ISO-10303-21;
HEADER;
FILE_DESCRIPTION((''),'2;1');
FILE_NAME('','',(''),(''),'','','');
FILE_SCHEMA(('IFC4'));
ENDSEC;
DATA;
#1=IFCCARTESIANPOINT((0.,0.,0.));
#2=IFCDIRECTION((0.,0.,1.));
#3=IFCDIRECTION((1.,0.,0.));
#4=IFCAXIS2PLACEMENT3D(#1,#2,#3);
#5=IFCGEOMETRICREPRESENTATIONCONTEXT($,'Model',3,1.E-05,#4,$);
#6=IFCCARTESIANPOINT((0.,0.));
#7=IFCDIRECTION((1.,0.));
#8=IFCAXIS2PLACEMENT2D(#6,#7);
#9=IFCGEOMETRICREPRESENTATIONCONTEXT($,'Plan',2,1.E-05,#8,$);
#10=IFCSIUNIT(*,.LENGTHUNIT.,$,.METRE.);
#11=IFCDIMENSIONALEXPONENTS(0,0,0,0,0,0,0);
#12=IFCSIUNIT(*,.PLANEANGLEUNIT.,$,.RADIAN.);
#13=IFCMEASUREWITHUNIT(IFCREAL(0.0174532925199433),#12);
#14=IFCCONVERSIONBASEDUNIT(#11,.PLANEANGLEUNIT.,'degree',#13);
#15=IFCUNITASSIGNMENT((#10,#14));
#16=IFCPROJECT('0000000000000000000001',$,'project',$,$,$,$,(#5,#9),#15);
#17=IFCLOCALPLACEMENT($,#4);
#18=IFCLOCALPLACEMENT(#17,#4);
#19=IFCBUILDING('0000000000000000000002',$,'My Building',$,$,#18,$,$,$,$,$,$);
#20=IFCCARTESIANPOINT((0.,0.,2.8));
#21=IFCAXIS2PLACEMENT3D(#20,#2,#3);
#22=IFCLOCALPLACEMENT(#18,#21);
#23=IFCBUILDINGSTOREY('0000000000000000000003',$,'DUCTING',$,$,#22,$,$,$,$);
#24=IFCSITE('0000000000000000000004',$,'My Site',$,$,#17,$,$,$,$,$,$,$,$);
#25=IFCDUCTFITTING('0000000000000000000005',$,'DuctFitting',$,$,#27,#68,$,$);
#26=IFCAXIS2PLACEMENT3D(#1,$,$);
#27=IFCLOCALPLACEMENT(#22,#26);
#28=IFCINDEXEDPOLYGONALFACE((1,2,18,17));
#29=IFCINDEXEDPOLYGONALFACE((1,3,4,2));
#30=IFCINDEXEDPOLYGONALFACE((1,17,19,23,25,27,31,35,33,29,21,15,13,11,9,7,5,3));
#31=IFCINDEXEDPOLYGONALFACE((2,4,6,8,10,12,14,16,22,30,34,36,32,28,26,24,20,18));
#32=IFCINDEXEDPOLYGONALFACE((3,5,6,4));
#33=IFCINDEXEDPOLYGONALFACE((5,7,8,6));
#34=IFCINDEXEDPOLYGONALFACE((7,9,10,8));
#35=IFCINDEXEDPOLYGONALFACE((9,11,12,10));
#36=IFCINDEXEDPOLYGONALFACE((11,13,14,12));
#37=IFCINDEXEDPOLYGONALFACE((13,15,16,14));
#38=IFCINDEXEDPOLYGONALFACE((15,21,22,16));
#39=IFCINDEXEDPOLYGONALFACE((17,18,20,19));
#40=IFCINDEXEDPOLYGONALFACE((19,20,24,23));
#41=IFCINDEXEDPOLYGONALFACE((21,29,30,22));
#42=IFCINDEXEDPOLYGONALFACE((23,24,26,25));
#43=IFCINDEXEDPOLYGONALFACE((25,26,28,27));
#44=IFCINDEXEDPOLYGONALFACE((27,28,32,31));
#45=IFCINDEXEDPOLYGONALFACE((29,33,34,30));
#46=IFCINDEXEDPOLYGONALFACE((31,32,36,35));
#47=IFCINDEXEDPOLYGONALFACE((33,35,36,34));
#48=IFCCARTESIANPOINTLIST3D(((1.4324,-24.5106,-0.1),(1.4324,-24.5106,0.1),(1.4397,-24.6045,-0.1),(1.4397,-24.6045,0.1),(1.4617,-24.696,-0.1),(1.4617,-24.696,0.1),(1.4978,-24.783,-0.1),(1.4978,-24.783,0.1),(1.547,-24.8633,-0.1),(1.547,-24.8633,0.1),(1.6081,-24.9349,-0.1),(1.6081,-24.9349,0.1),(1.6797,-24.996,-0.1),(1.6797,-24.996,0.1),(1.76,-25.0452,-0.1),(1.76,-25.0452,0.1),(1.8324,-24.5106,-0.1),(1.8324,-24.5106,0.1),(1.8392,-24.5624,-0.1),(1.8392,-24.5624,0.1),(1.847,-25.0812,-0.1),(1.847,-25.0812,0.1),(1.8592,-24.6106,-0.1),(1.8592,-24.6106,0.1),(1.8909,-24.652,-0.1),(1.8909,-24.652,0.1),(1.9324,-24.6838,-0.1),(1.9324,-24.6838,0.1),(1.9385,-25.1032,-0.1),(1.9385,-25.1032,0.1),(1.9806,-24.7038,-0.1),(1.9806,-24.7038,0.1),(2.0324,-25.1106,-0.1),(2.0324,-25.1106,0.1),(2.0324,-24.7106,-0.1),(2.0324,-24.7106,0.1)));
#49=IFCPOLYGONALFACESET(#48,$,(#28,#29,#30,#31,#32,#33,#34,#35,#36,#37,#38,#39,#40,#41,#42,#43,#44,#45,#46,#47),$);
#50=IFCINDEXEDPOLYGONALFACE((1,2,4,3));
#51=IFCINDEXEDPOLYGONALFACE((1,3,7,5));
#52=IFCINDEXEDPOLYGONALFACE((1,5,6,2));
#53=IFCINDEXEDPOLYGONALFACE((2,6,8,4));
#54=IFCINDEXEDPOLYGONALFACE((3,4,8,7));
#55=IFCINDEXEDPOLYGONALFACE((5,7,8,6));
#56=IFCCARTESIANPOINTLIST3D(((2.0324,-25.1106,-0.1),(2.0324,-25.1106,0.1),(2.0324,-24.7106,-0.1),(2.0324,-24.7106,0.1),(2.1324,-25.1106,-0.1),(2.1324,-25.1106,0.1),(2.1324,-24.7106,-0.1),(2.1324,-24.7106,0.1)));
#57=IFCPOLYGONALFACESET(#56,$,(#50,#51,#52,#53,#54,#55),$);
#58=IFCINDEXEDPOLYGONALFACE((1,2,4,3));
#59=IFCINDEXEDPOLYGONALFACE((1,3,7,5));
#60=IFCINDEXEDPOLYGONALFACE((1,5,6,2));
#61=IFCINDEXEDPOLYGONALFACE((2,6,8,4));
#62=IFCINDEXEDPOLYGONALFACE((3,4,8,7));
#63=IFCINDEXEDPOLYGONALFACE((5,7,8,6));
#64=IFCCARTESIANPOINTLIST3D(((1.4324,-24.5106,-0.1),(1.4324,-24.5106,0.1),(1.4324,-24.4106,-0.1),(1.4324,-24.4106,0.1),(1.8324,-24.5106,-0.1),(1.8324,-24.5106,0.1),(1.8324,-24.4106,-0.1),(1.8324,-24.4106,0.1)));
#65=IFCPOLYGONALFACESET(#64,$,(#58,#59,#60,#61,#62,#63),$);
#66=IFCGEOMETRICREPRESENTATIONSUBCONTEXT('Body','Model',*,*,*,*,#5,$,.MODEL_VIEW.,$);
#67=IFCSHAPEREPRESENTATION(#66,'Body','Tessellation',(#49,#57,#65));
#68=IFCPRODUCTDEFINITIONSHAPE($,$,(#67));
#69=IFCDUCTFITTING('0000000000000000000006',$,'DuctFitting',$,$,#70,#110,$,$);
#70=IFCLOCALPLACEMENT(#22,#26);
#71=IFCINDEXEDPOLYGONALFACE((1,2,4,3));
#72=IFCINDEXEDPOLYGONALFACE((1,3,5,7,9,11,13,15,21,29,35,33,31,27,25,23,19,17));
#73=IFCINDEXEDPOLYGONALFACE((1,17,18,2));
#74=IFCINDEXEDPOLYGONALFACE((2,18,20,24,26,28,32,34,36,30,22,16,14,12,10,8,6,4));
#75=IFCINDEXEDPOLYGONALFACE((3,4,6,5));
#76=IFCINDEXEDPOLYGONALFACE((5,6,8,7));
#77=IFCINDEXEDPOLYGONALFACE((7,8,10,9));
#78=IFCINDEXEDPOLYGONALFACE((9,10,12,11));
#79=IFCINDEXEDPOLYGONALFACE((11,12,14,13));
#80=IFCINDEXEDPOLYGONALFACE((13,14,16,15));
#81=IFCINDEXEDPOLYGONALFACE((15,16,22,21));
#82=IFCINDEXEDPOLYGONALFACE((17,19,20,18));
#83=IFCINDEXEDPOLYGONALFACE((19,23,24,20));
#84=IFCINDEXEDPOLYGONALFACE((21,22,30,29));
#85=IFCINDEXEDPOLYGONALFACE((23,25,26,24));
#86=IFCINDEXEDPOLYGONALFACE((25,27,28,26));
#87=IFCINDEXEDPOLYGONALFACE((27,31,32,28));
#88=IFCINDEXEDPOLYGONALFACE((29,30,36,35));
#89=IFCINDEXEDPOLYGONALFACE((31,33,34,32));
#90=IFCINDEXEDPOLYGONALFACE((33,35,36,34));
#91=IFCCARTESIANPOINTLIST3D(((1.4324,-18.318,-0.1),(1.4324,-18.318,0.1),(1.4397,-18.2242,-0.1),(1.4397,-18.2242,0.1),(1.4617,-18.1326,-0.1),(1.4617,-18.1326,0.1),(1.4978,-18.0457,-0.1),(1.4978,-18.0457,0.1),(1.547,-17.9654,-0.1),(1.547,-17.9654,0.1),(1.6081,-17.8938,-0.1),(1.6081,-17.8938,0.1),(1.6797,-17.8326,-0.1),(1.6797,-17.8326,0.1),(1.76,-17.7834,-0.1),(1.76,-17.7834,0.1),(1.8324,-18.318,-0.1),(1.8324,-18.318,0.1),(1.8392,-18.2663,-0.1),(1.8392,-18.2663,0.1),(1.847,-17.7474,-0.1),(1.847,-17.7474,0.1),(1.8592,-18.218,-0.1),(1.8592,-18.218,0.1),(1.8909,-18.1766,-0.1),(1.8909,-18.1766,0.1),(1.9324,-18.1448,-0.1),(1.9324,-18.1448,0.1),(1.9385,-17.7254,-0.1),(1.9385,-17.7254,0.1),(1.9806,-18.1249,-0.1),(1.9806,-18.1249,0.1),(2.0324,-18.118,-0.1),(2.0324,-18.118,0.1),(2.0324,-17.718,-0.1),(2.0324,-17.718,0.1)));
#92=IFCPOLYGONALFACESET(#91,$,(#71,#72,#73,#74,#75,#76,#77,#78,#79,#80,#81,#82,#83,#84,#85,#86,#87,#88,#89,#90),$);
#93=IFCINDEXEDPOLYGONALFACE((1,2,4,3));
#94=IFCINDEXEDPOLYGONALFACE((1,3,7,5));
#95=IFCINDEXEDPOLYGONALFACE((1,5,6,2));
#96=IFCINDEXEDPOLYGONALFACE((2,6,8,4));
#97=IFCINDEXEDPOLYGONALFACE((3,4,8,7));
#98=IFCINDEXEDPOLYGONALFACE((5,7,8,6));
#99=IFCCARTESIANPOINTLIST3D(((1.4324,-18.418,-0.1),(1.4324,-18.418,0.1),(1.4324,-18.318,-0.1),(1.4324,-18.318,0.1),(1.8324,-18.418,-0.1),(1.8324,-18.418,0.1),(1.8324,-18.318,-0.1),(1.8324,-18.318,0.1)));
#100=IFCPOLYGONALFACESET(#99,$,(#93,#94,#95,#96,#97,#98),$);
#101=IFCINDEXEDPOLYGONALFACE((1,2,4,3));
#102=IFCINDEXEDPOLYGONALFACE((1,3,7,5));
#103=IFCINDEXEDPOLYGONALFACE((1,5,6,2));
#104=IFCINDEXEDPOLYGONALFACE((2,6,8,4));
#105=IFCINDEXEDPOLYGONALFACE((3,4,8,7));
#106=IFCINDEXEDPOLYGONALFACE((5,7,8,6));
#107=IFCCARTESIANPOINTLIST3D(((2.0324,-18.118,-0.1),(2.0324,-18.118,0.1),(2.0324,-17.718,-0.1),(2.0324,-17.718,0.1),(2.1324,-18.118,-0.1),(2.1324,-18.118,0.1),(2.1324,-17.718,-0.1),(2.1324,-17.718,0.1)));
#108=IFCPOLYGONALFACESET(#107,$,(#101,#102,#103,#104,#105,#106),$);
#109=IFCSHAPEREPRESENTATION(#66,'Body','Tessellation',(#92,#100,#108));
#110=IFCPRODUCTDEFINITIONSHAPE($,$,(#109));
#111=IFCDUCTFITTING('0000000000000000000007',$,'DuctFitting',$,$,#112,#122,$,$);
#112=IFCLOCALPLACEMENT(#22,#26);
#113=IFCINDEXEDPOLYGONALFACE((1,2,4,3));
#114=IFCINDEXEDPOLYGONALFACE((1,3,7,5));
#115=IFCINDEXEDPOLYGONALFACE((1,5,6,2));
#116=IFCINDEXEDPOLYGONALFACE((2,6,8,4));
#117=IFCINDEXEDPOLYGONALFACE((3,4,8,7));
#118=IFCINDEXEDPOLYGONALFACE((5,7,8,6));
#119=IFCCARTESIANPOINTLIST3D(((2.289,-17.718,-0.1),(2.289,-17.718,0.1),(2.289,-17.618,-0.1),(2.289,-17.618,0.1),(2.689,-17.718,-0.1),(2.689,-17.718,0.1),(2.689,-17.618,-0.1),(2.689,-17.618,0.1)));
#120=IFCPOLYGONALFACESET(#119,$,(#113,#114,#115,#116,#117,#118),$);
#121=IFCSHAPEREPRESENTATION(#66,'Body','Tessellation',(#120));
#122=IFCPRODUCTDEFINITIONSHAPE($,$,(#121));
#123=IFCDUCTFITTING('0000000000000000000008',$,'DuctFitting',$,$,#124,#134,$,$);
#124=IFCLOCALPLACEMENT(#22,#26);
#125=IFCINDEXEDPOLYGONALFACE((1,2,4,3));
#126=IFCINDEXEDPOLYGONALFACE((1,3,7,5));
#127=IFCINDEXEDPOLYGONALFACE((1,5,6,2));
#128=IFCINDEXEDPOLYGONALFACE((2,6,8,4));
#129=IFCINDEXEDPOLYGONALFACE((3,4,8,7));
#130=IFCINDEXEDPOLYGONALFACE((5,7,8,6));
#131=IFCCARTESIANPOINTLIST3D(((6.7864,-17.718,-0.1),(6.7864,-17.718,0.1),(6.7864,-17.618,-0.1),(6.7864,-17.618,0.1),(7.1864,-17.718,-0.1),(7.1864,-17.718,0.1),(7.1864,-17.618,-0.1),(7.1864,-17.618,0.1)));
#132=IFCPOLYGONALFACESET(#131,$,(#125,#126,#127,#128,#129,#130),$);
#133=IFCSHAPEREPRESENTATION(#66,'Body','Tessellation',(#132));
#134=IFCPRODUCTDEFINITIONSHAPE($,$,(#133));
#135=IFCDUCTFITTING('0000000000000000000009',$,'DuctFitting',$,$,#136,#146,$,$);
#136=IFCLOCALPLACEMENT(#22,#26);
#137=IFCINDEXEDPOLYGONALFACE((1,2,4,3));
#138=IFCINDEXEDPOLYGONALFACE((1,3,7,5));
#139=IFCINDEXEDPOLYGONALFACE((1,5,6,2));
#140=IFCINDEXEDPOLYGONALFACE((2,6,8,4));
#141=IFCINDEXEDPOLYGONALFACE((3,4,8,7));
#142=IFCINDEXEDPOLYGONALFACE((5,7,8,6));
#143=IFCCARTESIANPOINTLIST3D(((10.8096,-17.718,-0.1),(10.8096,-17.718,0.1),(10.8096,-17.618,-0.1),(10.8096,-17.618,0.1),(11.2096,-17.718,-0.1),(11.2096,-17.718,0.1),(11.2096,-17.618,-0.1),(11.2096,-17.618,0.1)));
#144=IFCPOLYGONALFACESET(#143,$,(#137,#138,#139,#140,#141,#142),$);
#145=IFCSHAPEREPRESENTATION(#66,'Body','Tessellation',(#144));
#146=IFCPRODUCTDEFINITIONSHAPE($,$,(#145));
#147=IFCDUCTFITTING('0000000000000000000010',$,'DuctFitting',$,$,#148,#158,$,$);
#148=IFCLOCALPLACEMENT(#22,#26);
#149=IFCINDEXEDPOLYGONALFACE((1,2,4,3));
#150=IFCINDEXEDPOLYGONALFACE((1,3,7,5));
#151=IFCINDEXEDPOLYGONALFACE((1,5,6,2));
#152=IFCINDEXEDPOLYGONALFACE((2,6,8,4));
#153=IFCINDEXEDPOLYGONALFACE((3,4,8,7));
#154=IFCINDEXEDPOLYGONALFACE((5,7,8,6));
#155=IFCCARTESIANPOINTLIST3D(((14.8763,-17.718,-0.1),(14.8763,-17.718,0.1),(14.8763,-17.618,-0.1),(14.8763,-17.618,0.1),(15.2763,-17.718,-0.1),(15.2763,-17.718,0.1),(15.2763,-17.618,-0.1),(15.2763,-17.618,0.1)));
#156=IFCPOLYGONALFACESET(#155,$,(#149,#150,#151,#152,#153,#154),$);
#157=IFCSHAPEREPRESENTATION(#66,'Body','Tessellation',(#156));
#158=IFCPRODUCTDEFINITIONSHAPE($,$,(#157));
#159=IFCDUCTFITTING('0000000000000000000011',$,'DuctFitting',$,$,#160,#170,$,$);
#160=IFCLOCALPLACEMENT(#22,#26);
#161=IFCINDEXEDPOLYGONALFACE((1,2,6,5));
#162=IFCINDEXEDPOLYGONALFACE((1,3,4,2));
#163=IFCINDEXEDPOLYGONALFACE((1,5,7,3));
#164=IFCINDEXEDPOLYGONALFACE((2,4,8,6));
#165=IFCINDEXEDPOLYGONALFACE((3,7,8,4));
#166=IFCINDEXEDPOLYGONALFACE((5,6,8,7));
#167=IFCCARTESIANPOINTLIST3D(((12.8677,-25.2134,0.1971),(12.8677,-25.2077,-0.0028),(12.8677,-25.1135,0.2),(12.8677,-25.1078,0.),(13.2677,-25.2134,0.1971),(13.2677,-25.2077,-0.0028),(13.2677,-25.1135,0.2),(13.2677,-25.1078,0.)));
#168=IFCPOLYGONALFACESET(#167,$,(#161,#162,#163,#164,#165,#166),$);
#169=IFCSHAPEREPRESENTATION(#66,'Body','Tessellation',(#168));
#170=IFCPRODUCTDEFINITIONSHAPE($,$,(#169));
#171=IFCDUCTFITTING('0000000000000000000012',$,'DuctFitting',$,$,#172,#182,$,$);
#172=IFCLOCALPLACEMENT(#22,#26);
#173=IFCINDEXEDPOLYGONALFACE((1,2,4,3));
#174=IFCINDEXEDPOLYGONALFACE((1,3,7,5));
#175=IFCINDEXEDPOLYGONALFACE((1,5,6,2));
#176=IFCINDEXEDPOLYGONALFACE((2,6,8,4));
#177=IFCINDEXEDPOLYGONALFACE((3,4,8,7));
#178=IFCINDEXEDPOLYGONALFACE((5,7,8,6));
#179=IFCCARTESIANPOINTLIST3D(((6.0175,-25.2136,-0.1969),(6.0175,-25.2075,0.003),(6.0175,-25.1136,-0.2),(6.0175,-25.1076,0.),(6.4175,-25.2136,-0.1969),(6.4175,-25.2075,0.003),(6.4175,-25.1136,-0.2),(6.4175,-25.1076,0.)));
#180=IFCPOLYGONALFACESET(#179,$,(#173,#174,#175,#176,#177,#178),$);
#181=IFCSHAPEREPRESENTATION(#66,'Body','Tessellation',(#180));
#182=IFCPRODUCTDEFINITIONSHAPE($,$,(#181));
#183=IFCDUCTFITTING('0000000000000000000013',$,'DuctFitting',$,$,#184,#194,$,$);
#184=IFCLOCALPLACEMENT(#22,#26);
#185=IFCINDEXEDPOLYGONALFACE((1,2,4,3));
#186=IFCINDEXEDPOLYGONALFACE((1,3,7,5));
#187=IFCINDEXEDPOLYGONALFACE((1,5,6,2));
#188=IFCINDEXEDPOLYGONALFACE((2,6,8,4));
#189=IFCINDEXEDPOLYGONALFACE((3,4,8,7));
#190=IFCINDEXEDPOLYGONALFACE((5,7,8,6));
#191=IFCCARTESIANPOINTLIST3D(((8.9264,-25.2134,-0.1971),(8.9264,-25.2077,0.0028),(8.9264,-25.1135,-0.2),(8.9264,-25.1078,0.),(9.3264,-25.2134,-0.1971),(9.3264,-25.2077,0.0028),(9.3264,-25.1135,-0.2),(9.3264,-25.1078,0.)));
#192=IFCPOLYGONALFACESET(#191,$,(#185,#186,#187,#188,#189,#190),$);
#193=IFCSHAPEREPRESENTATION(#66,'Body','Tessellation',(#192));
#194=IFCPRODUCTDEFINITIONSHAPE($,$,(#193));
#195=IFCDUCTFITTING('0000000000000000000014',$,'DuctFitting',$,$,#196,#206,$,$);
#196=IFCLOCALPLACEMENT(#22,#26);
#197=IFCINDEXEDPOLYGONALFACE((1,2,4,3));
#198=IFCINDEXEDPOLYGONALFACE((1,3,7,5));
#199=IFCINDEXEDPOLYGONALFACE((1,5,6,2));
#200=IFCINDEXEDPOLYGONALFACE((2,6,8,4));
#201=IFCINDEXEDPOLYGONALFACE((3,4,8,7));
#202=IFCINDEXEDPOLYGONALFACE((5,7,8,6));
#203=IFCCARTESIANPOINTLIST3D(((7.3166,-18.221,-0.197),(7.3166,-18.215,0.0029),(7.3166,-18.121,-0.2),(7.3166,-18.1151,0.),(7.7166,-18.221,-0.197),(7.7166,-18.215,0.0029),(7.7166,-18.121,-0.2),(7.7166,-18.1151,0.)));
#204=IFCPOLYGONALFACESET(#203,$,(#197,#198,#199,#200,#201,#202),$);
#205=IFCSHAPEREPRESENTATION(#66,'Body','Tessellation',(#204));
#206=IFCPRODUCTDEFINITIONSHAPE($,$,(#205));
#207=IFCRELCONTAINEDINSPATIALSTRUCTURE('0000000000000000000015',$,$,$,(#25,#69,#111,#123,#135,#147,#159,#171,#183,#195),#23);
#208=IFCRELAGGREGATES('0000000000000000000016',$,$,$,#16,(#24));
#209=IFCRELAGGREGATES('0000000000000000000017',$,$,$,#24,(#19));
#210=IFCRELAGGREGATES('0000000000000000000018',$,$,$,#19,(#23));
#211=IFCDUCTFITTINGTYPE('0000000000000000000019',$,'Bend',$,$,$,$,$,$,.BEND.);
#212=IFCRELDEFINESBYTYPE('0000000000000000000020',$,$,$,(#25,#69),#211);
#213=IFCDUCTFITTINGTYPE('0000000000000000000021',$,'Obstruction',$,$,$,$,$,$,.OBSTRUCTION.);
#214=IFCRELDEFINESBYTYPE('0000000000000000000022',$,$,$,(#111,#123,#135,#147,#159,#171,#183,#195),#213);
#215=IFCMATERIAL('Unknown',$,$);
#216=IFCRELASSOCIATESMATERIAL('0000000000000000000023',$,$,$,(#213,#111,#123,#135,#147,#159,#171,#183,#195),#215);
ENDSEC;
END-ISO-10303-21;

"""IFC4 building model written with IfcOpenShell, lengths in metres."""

from ifc_helpers import new_model, entity, si_unit, converted_unit, frame, origin_with_axes, origin_2d_with_axis, place, context, subcontext, project, spatial, line, arc, indexed_curve, rectangle, outline, extrude, source, transform, mapped, material, material_profile, profile_set, profile_usage, type_object, type_shapes, element, save


model = new_model("IFC4")

# Units and contexts
model_context = context("Model", 3, precision=1e-05, world=origin_with_axes())
plan_context = context("Plan", 2, precision=1e-05, world=origin_2d_with_axis())
body_context = subcontext(model_context, "Body", "Model", "MODEL_VIEW")
ifc_project = project(units=[si_unit("LENGTHUNIT", "METRE"), converted_unit("PLANEANGLEUNIT", "degree", entity("IfcReal", 0.0174532925199433), si_unit("PLANEANGLEUNIT", "RADIAN"), dimensions=[0, 0, 0, 0, 0, 0, 0])], contexts=[model_context, plan_context])

# Site, building, storey
site_placement = place(None, origin_with_axes())
site = spatial("IfcSite", under=ifc_project, at=site_placement, Name="My Site")
building_placement = place(site_placement, origin_with_axes())
building = spatial("IfcBuilding", under=site, at=building_placement, Name="My Building")
storey_placement = place(building_placement, frame((0.0, 0.0, 2.8), z_axis=(0.0, 0.0, 1.0), x_axis=(1.0, 0.0, 0.0)))
storey = spatial("IfcBuildingStorey", under=building, at=storey_placement, Name="DUCTING")

# Shared definitions
ifc_material = material(Name="Unknown")

# Duct fittings
duct_fitting_type_1 = type_object("IfcDuctFittingType", Name="Bend", PredefinedType="BEND")
shared_shape = source(origin_with_axes(), body_context, "Body", "SweptSolid", [
    extrude(outline(indexed_curve([(-0.2, 0.0), (-0.2586, -0.1414), (-0.4, -0.2), (-0.4, -0.6), (0.0243, -0.4243), (0.2, 0.0)], segments=[arc(1, 2, 3), line(3, 4), arc(4, 5, 6), line(6, 1)])), frame((0.0, -0.1, -0.1), z_axis=(0.0, -1.0, 0.0), x_axis=(1.0, 0.0, 0.0)), (0.0, 0.0, -1.0), 0.2),
    extrude(rectangle(XDim=0.4, YDim=0.2), origin_with_axes(), (0.0, 0.0, -1.0), 0.1),
    extrude(rectangle(XDim=0.4, YDim=0.2), frame((-0.4, 0.0, -0.5), z_axis=(-1.0, 0.0, 0.0), x_axis=(0.0, 0.0, -1.0)), (0.0, 0.0, 1.0), 0.1),
])
type_shapes(duct_fitting_type_1, [shared_shape])
for number, where, z_axis, x_axis, name in (
    (1, (2.1324, -24.9106, 0.0), (1.0, 0.0, 0.0), (0.0, -1.0, 0.0), "DuctFitting"),
    (2, (1.6324, -18.418, 0.0), (0.0, -1.0, 0.0), (-1.0, 0.0, 0.0), "DuctFitting"),
):
    element("IfcDuctFitting", number, at=place(storey_placement, frame(where, z_axis=z_axis, x_axis=x_axis)), inside=storey, type_object=duct_fitting_type_1, Name=name, context=body_context, shape_type="MappedRepresentation", body=[
        mapped(shared_shape, transform((0.0, 0.0, 0.0), x_axis=(1.0, 0.0, 0.0), y_axis=(0.0, 1.0, 0.0), z_axis=(0.0, 0.0, 1.0), scale=1.0)),
    ])
ifc_material_profile_1 = material_profile(ifc_material, rectangle(XDim=0.4, YDim=0.2))
ifc_profile_set_1 = profile_set([ifc_material_profile_1])
ifc_profile_usage_1 = profile_usage(ifc_profile_set_1, cardinal=5)
duct_fitting_type_2 = type_object("IfcDuctFittingType", Name="Obstruction", PredefinedType="OBSTRUCTION", material=ifc_profile_set_1)
duct_fitting_1_placement = place(storey_placement, frame((2.489, -17.718, 0.0), z_axis=(0.0, 1.0, 0.0), x_axis=(-1.0, 0.0, 0.0)))
element("IfcDuctFitting", 3, at=duct_fitting_1_placement, inside=storey, type_object=duct_fitting_type_2, material=ifc_profile_usage_1, Name="DuctFitting", context=body_context, shape_type="SweptSolid", body=[
    extrude(rectangle(XDim=0.4, YDim=0.2), origin_with_axes(), (0.0, 0.0, 1.0), 0.1),
])
ifc_profile_usage_2 = profile_usage(ifc_profile_set_1, cardinal=5)
duct_fitting_2_placement = place(storey_placement, frame((6.9864, -17.718, 0.0), z_axis=(0.0, 1.0, 0.0), x_axis=(-1.0, 0.0, 0.0)))
element("IfcDuctFitting", 4, at=duct_fitting_2_placement, inside=storey, type_object=duct_fitting_type_2, material=ifc_profile_usage_2, Name="DuctFitting", context=body_context, shape_type="SweptSolid", body=[
    extrude(rectangle(XDim=0.4, YDim=0.2), origin_with_axes(), (0.0, 0.0, 1.0), 0.1),
])
ifc_profile_usage_3 = profile_usage(ifc_profile_set_1, cardinal=5)
duct_fitting_3_placement = place(storey_placement, frame((11.0096, -17.718, 0.0), z_axis=(0.0, 1.0, 0.0), x_axis=(-1.0, 0.0, 0.0)))
element("IfcDuctFitting", 5, at=duct_fitting_3_placement, inside=storey, type_object=duct_fitting_type_2, material=ifc_profile_usage_3, Name="DuctFitting", context=body_context, shape_type="SweptSolid", body=[
    extrude(rectangle(XDim=0.4, YDim=0.2), origin_with_axes(), (0.0, 0.0, 1.0), 0.1),
])
ifc_profile_usage_4 = profile_usage(ifc_profile_set_1, cardinal=5)
duct_fitting_4_placement = place(storey_placement, frame((15.0763, -17.718, 0.0), z_axis=(0.0, 1.0, 0.0), x_axis=(-1.0, 0.0, 0.0)))
element("IfcDuctFitting", 6, at=duct_fitting_4_placement, inside=storey, type_object=duct_fitting_type_2, material=ifc_profile_usage_4, Name="DuctFitting", context=body_context, shape_type="SweptSolid", body=[
    extrude(rectangle(XDim=0.4, YDim=0.2), origin_with_axes(), (0.0, 0.0, 1.0), 0.1),
])
ifc_profile_usage_5 = profile_usage(ifc_profile_set_1, cardinal=5)
duct_fitting_5_placement = place(storey_placement, frame((13.0677, -25.1106, 0.1), z_axis=(-0.000001, -0.999595, -0.028447), x_axis=(1.0, -0.000001, 0.0)))
element("IfcDuctFitting", 7, at=duct_fitting_5_placement, inside=storey, type_object=duct_fitting_type_2, material=ifc_profile_usage_5, Name="DuctFitting", context=body_context, shape_type="SweptSolid", body=[
    extrude(rectangle(XDim=0.4, YDim=0.2), origin_with_axes(), (0.0, 0.0, 1.0), 0.1),
])
ifc_profile_usage_6 = profile_usage(ifc_profile_set_1, cardinal=5)
duct_fitting_6_placement = place(storey_placement, frame((6.2175, -25.1106, -0.1), z_axis=(0.0, -0.999543, 0.030233), x_axis=(1.0, 0.0, 0.0)))
element("IfcDuctFitting", 8, at=duct_fitting_6_placement, inside=storey, type_object=duct_fitting_type_2, material=ifc_profile_usage_6, Name="DuctFitting", context=body_context, shape_type="SweptSolid", body=[
    extrude(rectangle(XDim=0.4, YDim=0.2), origin_with_axes(), (0.0, 0.0, 1.0), 0.1),
])
ifc_profile_usage_7 = profile_usage(ifc_profile_set_1, cardinal=5)
duct_fitting_7_placement = place(storey_placement, frame((9.1264, -25.1106, -0.1), z_axis=(0.0, -0.999595, 0.028448), x_axis=(1.0, 0.0, 0.0)))
element("IfcDuctFitting", 9, at=duct_fitting_7_placement, inside=storey, type_object=duct_fitting_type_2, material=ifc_profile_usage_7, Name="DuctFitting", context=body_context, shape_type="SweptSolid", body=[
    extrude(rectangle(XDim=0.4, YDim=0.2), origin_with_axes(), (0.0, 0.0, 1.0), 0.1),
])
ifc_profile_usage_8 = profile_usage(ifc_profile_set_1, cardinal=5)
duct_fitting_8_placement = place(storey_placement, frame((7.5166, -18.118, -0.1), z_axis=(0.0, -0.999553, 0.029909), x_axis=(1.0, 0.0, 0.0)))
element("IfcDuctFitting", 10, at=duct_fitting_8_placement, inside=storey, type_object=duct_fitting_type_2, material=ifc_profile_usage_8, Name="DuctFitting", context=body_context, shape_type="SweptSolid", body=[
    extrude(rectangle(XDim=0.4, YDim=0.2), origin_with_axes(), (0.0, 0.0, 1.0), 0.1),
])

save(model, "model.ifc")
